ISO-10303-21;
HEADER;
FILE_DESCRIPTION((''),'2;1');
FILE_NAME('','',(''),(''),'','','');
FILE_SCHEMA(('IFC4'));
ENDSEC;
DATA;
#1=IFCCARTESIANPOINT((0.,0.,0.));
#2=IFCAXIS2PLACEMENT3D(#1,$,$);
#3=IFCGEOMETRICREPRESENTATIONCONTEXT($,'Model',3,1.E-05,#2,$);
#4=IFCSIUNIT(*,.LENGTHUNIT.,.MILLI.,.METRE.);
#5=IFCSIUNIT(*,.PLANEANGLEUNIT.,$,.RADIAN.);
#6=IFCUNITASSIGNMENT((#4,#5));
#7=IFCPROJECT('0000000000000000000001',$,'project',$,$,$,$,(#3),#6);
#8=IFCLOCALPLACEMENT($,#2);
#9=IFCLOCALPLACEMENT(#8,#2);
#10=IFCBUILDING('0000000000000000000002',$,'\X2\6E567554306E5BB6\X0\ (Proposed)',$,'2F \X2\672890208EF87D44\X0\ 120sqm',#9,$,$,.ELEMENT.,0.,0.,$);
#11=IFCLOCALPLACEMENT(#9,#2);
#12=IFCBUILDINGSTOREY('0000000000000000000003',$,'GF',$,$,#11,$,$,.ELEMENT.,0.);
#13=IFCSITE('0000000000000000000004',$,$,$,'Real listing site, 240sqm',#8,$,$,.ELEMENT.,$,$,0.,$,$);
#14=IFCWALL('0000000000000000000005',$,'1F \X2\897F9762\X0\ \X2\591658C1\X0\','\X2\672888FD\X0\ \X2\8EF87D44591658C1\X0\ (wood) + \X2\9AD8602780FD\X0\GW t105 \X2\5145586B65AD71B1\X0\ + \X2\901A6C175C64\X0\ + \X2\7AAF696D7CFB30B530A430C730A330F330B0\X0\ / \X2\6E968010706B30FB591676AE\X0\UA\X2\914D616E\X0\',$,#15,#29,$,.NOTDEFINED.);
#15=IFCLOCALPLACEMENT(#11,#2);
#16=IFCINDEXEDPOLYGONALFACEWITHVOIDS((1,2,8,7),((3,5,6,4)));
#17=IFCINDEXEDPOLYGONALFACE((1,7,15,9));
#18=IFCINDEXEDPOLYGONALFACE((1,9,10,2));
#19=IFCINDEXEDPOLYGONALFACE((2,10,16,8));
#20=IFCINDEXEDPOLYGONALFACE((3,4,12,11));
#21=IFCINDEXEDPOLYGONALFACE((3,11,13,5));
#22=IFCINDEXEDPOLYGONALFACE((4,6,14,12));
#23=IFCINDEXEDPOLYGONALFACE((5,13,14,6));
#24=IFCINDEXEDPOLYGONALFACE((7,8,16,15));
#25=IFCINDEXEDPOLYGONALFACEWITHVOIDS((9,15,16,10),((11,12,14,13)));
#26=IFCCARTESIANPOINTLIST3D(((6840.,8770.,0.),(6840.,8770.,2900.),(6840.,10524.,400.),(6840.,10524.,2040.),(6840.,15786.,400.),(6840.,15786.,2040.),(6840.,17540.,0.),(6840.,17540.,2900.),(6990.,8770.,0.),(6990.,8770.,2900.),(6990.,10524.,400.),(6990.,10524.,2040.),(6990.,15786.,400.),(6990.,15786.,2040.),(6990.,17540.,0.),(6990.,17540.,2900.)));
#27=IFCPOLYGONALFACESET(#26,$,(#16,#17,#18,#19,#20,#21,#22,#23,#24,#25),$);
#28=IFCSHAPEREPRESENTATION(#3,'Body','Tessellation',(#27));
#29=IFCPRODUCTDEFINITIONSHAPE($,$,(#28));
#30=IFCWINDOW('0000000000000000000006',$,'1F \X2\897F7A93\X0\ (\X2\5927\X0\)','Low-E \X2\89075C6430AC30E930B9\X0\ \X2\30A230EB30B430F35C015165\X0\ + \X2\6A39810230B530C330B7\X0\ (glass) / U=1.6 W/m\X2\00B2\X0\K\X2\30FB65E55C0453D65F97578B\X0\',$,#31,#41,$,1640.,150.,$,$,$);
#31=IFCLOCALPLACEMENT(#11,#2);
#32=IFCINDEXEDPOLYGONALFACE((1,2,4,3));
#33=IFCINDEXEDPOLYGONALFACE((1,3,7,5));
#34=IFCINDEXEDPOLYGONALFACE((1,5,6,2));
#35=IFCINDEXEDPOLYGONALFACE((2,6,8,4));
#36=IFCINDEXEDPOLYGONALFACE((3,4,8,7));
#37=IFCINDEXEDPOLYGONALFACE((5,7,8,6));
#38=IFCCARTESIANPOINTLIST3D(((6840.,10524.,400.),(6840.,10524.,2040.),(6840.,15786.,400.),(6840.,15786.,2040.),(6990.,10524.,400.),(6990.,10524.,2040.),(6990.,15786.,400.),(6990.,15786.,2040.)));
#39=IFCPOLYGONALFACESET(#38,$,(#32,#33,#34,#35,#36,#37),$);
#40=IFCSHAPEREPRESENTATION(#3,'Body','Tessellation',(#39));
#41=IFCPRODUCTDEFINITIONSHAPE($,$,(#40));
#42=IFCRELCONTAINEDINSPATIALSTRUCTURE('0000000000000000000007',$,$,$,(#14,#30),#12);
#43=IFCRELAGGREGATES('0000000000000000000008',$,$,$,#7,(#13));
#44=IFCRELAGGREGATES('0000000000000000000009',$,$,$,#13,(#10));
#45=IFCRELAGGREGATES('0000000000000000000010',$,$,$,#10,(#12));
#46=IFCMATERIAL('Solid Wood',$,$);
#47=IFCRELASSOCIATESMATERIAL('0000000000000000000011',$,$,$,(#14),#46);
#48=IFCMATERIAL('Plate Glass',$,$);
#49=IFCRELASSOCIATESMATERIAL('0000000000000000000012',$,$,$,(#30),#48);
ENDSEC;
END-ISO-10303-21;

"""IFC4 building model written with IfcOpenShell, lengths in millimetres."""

from ifc_helpers import new_model, si_unit, frame, frame_2d, origin, place, context, project, spatial, rectangle, extrude, material, element, fill, save


model = new_model("IFC4")

# Units and contexts
model_context = context("Model", 3, precision=1e-05, world=origin())
ifc_project = project(units=[si_unit("LENGTHUNIT", "METRE", prefix="MILLI"), si_unit("PLANEANGLEUNIT", "RADIAN")], contexts=[model_context])

# Site, building, storey
site_placement = place(None, origin())
site = spatial("IfcSite", under=ifc_project, at=site_placement, ObjectType="Real listing site, 240sqm", CompositionType="ELEMENT", RefElevation=0.0)
building_placement = place(site_placement, origin())
building = spatial("IfcBuilding", under=site, at=building_placement, Name="湖畔の家 (Proposed)", ObjectType="2F 木造軸組 120sqm", CompositionType="ELEMENT", ElevationOfRefHeight=0.0, ElevationOfTerrain=0.0)
storey_placement = place(building_placement, origin())
storey = spatial("IfcBuildingStorey", under=building, at=storey_placement, Name="GF", CompositionType="ELEMENT", Elevation=0.0)

# Shared definitions
ifc_material_1 = material(Name="Solid Wood")

# Shared definitions
ifc_material_2 = material(Name="Plate Glass")

# Wall, opening, window
wall_1_placement = place(storey_placement, frame((3420.0, 4385.0, 0.0)))
wall_1 = element("IfcWall", 1, at=wall_1_placement, inside=storey, material=ifc_material_1, Name="1F 西面 外壁", Description="木製 軸組外壁 (wood) + 高性能GW t105 充填断熱 + 通気層 + 窯業系サイディング / 準耐火・外皮UA配慮", PredefinedType="NOTDEFINED", context=model_context, shape_type="SweptSolid", body=[
    extrude(rectangle(XDim=150.0, YDim=8770.0, at=frame_2d((75.0, 4385.0))), frame((3420.0, 4385.0, 0.0)), (0.0, 0.0, 1.0), 2900.0),
])
opening_1_placement = place(storey_placement, frame((3420.0, 5262.0, 200.0)))
opening_1 = element("IfcOpeningElement", 2, at=opening_1_placement, cuts=wall_1, PredefinedType="NOTDEFINED", context=model_context, shape_type="SweptSolid", body=[
    extrude(rectangle(XDim=150.0, YDim=5262.0, at=frame_2d((75.0, 2631.0))), frame((3420.0, 5262.0, 200.0)), (0.0, 0.0, 1.0), 1640.0),
])
window_1_placement = place(storey_placement, frame((3420.0, 5262.0, 200.0)))
window_1 = element("IfcWindow", 3, at=window_1_placement, inside=storey, material=ifc_material_2, Name="1F 西窓 (大)", Description="Low-E 複層ガラス アルゴン封入 + 樹脂サッシ (glass) / U=1.6 W/m²K・日射取得型", OverallHeight=1640.0, OverallWidth=150.0, context=model_context, shape_type="SweptSolid", body=[
    extrude(rectangle(XDim=150.0, YDim=5262.0, at=frame_2d((75.0, 2631.0))), frame((3420.0, 5262.0, 200.0)), (0.0, 0.0, 1.0), 1640.0),
])
fill(opening_1, window_1)

save(model, "model.ifc")
